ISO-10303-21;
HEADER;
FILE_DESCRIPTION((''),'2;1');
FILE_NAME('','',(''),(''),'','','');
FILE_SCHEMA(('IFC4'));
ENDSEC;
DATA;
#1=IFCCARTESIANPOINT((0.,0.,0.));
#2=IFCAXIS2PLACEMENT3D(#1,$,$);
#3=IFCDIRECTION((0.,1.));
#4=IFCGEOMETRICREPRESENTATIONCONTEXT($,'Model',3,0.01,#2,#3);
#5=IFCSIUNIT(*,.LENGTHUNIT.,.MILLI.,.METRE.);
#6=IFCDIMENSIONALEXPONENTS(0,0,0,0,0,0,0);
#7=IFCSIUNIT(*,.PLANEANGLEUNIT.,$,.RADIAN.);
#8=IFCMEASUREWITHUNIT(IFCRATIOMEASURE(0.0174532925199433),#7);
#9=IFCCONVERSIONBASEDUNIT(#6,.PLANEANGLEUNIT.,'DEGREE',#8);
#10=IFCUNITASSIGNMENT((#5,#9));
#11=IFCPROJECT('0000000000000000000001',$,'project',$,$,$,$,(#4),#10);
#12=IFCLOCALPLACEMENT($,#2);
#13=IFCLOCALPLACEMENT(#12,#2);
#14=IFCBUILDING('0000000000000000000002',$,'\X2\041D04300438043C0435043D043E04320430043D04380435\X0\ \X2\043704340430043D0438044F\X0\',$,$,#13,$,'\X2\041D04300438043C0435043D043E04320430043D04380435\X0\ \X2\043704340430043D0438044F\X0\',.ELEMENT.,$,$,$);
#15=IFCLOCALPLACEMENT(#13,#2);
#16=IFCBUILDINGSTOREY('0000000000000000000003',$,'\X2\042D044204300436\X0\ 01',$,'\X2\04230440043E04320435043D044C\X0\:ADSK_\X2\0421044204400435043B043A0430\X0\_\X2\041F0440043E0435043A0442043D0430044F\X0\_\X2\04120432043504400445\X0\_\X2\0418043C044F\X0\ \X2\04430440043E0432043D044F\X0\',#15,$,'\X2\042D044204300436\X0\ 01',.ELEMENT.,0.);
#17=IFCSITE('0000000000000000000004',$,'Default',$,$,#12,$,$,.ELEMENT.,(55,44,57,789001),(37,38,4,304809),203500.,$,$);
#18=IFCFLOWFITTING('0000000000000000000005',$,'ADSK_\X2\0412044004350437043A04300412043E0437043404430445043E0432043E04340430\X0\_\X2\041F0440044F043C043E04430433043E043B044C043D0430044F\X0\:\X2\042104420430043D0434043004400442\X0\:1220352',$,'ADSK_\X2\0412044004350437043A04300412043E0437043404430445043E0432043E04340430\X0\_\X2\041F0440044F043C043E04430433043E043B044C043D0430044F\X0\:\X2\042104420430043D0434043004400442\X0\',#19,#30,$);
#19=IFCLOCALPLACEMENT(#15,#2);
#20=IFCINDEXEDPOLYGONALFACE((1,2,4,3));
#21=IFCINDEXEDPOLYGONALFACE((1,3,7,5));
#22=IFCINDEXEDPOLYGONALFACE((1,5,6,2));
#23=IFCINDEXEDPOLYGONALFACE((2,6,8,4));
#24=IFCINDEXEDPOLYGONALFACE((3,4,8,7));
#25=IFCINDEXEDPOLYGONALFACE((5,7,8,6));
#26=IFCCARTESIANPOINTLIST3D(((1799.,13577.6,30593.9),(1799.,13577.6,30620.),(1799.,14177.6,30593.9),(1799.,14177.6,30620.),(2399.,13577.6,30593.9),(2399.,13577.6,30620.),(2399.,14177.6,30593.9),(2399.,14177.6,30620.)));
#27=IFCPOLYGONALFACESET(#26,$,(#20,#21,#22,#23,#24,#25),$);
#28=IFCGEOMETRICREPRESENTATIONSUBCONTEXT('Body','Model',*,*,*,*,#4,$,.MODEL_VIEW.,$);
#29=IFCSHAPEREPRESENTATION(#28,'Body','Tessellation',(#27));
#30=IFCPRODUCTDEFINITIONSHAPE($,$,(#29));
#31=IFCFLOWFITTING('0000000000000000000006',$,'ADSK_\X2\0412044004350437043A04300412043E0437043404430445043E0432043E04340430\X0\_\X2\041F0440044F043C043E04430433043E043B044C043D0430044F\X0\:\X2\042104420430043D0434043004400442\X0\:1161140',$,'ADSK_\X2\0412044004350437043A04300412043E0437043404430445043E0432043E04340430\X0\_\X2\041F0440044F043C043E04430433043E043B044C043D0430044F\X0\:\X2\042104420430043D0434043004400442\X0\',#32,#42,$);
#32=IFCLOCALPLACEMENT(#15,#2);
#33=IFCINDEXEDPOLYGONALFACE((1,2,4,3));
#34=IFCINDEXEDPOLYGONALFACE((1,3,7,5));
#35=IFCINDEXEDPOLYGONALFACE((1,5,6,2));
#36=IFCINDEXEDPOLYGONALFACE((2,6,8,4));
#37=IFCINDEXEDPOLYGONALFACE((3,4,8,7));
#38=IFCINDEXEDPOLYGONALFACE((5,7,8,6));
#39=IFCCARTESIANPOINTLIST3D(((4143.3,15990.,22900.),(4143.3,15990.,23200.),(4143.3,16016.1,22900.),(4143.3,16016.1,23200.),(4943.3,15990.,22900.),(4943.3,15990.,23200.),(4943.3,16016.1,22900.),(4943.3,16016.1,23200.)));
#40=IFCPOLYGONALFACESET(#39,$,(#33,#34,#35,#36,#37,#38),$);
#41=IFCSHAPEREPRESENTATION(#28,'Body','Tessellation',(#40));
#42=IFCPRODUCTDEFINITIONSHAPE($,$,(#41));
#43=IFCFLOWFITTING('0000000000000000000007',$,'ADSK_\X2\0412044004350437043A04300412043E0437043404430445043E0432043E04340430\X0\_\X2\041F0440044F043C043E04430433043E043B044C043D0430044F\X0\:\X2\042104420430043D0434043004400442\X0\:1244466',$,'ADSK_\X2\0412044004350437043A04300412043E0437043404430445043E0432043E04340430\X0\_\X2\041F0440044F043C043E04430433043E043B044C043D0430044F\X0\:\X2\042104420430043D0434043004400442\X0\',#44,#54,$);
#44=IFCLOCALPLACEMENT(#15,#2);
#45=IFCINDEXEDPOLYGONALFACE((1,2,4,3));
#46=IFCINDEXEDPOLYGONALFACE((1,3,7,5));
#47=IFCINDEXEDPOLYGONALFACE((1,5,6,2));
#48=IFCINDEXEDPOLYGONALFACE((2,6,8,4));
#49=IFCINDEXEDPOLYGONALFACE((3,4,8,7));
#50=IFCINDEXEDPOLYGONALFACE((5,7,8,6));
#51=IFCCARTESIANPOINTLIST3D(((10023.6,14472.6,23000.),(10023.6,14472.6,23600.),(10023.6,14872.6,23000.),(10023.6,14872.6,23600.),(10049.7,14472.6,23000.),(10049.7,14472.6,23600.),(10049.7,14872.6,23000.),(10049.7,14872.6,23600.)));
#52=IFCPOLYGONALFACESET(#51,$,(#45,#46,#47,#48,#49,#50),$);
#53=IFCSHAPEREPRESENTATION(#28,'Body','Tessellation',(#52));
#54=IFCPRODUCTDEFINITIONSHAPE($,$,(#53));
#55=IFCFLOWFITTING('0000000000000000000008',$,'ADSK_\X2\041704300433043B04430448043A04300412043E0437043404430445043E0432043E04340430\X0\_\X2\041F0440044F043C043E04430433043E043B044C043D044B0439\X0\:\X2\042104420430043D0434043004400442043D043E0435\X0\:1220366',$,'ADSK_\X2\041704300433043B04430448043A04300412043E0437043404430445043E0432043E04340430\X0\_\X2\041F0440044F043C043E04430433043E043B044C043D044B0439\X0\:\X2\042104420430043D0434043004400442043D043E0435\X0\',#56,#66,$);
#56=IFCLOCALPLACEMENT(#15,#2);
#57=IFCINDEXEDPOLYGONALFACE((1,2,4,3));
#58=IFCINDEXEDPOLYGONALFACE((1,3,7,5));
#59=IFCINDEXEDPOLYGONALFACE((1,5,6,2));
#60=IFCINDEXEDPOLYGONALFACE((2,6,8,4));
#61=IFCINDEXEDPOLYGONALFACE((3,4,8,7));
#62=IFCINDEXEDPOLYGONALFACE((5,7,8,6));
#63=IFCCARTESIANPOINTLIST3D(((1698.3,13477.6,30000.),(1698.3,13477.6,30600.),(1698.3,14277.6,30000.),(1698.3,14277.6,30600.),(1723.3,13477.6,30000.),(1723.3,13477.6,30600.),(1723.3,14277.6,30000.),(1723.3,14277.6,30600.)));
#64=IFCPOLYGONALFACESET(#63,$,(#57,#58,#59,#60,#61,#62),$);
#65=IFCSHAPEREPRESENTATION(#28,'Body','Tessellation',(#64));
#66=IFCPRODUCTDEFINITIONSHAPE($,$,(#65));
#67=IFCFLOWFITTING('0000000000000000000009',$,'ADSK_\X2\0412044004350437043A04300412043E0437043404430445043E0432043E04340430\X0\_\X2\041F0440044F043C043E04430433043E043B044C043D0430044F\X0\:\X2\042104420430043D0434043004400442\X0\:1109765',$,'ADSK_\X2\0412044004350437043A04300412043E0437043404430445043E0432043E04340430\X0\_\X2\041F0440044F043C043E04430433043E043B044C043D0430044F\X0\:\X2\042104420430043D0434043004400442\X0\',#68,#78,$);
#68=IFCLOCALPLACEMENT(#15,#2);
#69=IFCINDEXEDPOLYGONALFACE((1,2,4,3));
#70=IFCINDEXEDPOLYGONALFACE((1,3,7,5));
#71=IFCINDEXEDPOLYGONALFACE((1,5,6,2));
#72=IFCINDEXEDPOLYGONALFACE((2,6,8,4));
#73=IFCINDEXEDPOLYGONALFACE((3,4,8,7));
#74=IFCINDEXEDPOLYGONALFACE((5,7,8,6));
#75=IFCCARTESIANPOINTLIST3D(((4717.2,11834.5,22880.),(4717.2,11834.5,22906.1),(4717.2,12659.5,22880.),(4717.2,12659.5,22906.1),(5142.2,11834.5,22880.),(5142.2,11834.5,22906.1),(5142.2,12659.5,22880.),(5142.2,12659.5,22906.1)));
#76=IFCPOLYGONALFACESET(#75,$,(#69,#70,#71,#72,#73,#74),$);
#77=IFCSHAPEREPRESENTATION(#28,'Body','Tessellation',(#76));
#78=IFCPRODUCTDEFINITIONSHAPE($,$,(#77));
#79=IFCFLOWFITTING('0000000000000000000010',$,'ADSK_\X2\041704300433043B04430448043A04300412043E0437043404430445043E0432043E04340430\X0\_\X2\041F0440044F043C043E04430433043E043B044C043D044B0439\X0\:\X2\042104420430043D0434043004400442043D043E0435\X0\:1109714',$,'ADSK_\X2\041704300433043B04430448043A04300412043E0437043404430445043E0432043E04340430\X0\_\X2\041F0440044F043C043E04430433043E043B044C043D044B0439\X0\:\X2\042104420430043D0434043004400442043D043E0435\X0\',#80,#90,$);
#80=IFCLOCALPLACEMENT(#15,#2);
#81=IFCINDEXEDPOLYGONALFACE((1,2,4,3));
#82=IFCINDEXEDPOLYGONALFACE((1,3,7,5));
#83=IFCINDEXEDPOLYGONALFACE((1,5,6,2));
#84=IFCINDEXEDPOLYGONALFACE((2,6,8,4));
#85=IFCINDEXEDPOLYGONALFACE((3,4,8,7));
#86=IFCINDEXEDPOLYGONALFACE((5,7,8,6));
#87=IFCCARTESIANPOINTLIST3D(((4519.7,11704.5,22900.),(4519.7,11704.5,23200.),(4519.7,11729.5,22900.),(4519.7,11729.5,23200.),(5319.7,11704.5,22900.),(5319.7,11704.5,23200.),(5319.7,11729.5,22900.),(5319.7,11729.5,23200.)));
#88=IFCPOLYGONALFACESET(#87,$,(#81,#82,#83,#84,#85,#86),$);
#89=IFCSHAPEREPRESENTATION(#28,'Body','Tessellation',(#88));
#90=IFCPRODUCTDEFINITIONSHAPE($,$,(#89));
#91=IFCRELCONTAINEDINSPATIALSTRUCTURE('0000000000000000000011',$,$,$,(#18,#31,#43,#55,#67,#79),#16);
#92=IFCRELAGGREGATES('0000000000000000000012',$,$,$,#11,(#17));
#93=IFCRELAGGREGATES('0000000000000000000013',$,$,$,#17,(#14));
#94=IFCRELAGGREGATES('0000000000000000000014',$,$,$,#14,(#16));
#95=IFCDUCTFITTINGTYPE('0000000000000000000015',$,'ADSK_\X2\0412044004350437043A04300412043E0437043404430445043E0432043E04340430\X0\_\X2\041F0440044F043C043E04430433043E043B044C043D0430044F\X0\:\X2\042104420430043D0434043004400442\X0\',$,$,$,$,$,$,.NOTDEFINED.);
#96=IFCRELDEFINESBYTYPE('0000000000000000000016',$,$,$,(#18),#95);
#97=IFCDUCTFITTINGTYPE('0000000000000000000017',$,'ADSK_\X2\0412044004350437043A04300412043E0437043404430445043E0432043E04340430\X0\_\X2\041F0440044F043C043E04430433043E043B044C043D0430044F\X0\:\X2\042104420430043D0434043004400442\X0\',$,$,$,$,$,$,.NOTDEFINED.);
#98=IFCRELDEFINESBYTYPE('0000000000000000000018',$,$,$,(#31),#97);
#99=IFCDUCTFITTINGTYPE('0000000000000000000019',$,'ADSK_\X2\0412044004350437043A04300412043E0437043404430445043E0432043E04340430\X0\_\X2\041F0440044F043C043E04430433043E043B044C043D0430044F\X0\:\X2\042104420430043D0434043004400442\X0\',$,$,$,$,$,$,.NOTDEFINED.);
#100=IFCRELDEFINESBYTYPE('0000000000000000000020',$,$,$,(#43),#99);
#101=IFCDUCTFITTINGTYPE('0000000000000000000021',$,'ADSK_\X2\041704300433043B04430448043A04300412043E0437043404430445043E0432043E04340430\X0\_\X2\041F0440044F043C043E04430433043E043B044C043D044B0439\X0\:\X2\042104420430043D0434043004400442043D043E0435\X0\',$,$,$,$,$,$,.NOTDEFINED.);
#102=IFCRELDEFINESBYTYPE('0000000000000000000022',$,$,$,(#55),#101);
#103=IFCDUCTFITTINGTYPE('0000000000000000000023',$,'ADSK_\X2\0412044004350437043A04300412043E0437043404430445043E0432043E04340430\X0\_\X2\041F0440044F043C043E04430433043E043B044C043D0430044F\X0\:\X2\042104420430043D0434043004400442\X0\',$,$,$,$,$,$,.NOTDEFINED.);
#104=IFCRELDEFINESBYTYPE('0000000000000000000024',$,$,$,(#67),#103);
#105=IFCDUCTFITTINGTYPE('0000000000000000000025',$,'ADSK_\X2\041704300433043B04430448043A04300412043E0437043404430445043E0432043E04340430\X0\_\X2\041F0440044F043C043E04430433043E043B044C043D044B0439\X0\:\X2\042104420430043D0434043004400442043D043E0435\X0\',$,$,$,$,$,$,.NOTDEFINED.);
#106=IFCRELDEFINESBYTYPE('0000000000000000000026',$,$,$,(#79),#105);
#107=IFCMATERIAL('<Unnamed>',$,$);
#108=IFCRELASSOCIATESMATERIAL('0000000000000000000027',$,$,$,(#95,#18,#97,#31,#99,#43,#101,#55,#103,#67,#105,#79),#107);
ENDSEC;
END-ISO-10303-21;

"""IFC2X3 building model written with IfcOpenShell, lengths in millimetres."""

from ifc_helpers import new_model, entity, si_unit, converted_unit, direction, frame, origin, origin_2d_with_axis, place, context, subcontext, project, spatial, rectangle, extrude, source, transform, mapped, material, type_object, type_shapes, element, save


model = new_model("IFC2X3")

# Units and contexts
model_context = context("Model", 3, precision=0.01, world=origin(), true_north=direction((0.0, 1.0)))
body_context = subcontext(model_context, "Body", "Model", "MODEL_VIEW")
ifc_project = project(units=[si_unit("LENGTHUNIT", "METRE", prefix="MILLI"), converted_unit("PLANEANGLEUNIT", "DEGREE", entity("IfcRatioMeasure", 0.0174532925199433), si_unit("PLANEANGLEUNIT", "RADIAN"), dimensions=[0, 0, 0, 0, 0, 0, 0])], contexts=[model_context])

# Site, building, storey
site_placement = place(None, origin())
site = spatial("IfcSite", under=ifc_project, at=site_placement, Name="Default", CompositionType="ELEMENT", RefLatitude=(55, 44, 57, 789001), RefLongitude=(37, 38, 4, 304809), RefElevation=203500.0)
building_placement = place(site_placement, origin())
building = spatial("IfcBuilding", under=site, at=building_placement, Name="Наименование здания", LongName="Наименование здания", CompositionType="ELEMENT")
storey_placement = place(building_placement, origin())
storey = spatial("IfcBuildingStorey", under=building, at=storey_placement, Name="Этаж 01", ObjectType="Уровень:ADSK_Стрелка_Проектная_Вверх_Имя уровня", LongName="Этаж 01", CompositionType="ELEMENT", Elevation=0.0)

# Flow fittings
ifc_material_1 = material(Name="<Unnamed>")
duct_fitting_type_1 = type_object("IfcDuctFittingType", Name="ADSK_ВрезкаВоздуховода_Прямоугольная:Стандарт", PredefinedType="NOTDEFINED", material=ifc_material_1)
shared_shape_1 = source(origin(), body_context, "Body", "SweptSolid", [
    extrude(rectangle(XDim=600.0, YDim=26.1, at=origin_2d_with_axis()), frame((7.0, 0.0, -300.0), z_axis=(0.0, 0.0, 1.0), x_axis=(0.0, -1.0, 0.0)), (0.0, 0.0, 1.0), 600.0),
])
type_shapes(duct_fitting_type_1, [shared_shape_1])
flow_fitting_1_placement = place(storey_placement, frame((2099.0, 13877.6, 30600.0), z_axis=(0.0, -1.0, 0.0), x_axis=(0.0, 0.0, 1.0)))
element("IfcFlowFitting", 1, at=flow_fitting_1_placement, inside=storey, type_object=duct_fitting_type_1, material=ifc_material_1, Name="ADSK_ВрезкаВоздуховода_Прямоугольная:Стандарт:1220352", ObjectType="ADSK_ВрезкаВоздуховода_Прямоугольная:Стандарт", context=body_context, shape_type="MappedRepresentation", body=[
    mapped(shared_shape_1, transform((0.0, 0.0, 0.0), scale=1.0)),
])
duct_fitting_type_2 = type_object("IfcDuctFittingType", Name="ADSK_ВрезкаВоздуховода_Прямоугольная:Стандарт", PredefinedType="NOTDEFINED", material=ifc_material_1)
shared_shape_2 = source(origin(), body_context, "Body", "SweptSolid", [
    extrude(rectangle(XDim=26.1, YDim=300.0, at=origin_2d_with_axis()), frame((7.0, 0.0, -400.0)), (0.0, 0.0, 1.0), 800.0),
])
type_shapes(duct_fitting_type_2, [shared_shape_2])
flow_fitting_2_placement = place(storey_placement, frame((4543.3, 16010.0, 23050.0), z_axis=(-1.0, 0.0, 0.0), x_axis=(0.0, -1.0, 0.0)))
element("IfcFlowFitting", 2, at=flow_fitting_2_placement, inside=storey, type_object=duct_fitting_type_2, material=ifc_material_1, Name="ADSK_ВрезкаВоздуховода_Прямоугольная:Стандарт:1161140", ObjectType="ADSK_ВрезкаВоздуховода_Прямоугольная:Стандарт", context=body_context, shape_type="MappedRepresentation", body=[
    mapped(shared_shape_2, transform((0.0, 0.0, 0.0), scale=1.0)),
])
duct_fitting_type_3 = type_object("IfcDuctFittingType", Name="ADSK_ВрезкаВоздуховода_Прямоугольная:Стандарт", PredefinedType="NOTDEFINED", material=ifc_material_1)
shared_shape_3 = source(origin(), body_context, "Body", "SweptSolid", [
    extrude(rectangle(XDim=600.0, YDim=26.1, at=origin_2d_with_axis()), frame((7.0, 0.0, -200.0), z_axis=(0.0, 0.0, 1.0), x_axis=(0.0, -1.0, 0.0)), (0.0, 0.0, 1.0), 400.0),
])
type_shapes(duct_fitting_type_3, [shared_shape_3])
flow_fitting_3_placement = place(storey_placement, frame((10029.7, 14672.6, 23300.0), z_axis=(0.0, -1.0, 0.0), x_axis=(1.0, 0.0, 0.0)))
element("IfcFlowFitting", 3, at=flow_fitting_3_placement, inside=storey, type_object=duct_fitting_type_3, material=ifc_material_1, Name="ADSK_ВрезкаВоздуховода_Прямоугольная:Стандарт:1244466", ObjectType="ADSK_ВрезкаВоздуховода_Прямоугольная:Стандарт", context=body_context, shape_type="MappedRepresentation", body=[
    mapped(shared_shape_3, transform((0.0, 0.0, 0.0), scale=1.0)),
])
duct_fitting_type_4 = type_object("IfcDuctFittingType", Name="ADSK_ЗаглушкаВоздуховода_Прямоугольный:Стандартное", PredefinedType="NOTDEFINED", material=ifc_material_1)
shared_shape_4 = source(origin(), body_context, "Body", "SweptSolid", [
    extrude(rectangle(XDim=25.0, YDim=800.0, at=origin_2d_with_axis()), frame((12.5, 0.0, -300.0)), (0.0, 0.0, 1.0), 600.0),
])
type_shapes(duct_fitting_type_4, [shared_shape_4])
flow_fitting_4_placement = place(storey_placement, frame((1723.3, 13877.6, 30300.0), z_axis=(0.0, 0.0, 1.0), x_axis=(-1.0, 0.0, 0.0)))
element("IfcFlowFitting", 4, at=flow_fitting_4_placement, inside=storey, type_object=duct_fitting_type_4, material=ifc_material_1, Name="ADSK_ЗаглушкаВоздуховода_Прямоугольный:Стандартное:1220366", ObjectType="ADSK_ЗаглушкаВоздуховода_Прямоугольный:Стандартное", context=body_context, shape_type="MappedRepresentation", body=[
    mapped(shared_shape_4, transform((0.0, 0.0, 0.0), scale=1.0)),
])
duct_fitting_type_5 = type_object("IfcDuctFittingType", Name="ADSK_ВрезкаВоздуховода_Прямоугольная:Стандарт", PredefinedType="NOTDEFINED", material=ifc_material_1)
shared_shape_5 = source(origin(), body_context, "Body", "SweptSolid", [
    extrude(rectangle(XDim=825.0, YDim=26.1, at=origin_2d_with_axis()), frame((7.0, 0.0, -212.5), z_axis=(0.0, 0.0, 1.0), x_axis=(0.0, -1.0, 0.0)), (0.0, 0.0, 1.0), 425.0),
])
type_shapes(duct_fitting_type_5, [shared_shape_5])
flow_fitting_5_placement = place(storey_placement, frame((4929.7, 12247.0, 22900.0), z_axis=(-1.0, 0.0, 0.0), x_axis=(0.0, 0.0, -1.0)))
element("IfcFlowFitting", 5, at=flow_fitting_5_placement, inside=storey, type_object=duct_fitting_type_5, material=ifc_material_1, Name="ADSK_ВрезкаВоздуховода_Прямоугольная:Стандарт:1109765", ObjectType="ADSK_ВрезкаВоздуховода_Прямоугольная:Стандарт", context=body_context, shape_type="MappedRepresentation", body=[
    mapped(shared_shape_5, transform((0.0, 0.0, 0.0), scale=1.0)),
])
duct_fitting_type_6 = type_object("IfcDuctFittingType", Name="ADSK_ЗаглушкаВоздуховода_Прямоугольный:Стандартное", PredefinedType="NOTDEFINED", material=ifc_material_1)
shared_shape_6 = source(origin(), body_context, "Body", "SweptSolid", [
    extrude(rectangle(XDim=25.0, YDim=800.0, at=origin_2d_with_axis()), frame((12.5, 0.0, -150.0)), (0.0, 0.0, 1.0), 300.0),
])
type_shapes(duct_fitting_type_6, [shared_shape_6])
flow_fitting_6_placement = place(storey_placement, frame((4919.7, 11729.5, 23050.0), z_axis=(0.0, 0.0, 1.0), x_axis=(0.0, -1.0, 0.0)))
element("IfcFlowFitting", 6, at=flow_fitting_6_placement, inside=storey, type_object=duct_fitting_type_6, material=ifc_material_1, Name="ADSK_ЗаглушкаВоздуховода_Прямоугольный:Стандартное:1109714", ObjectType="ADSK_ЗаглушкаВоздуховода_Прямоугольный:Стандартное", context=body_context, shape_type="MappedRepresentation", body=[
    mapped(shared_shape_6, transform((0.0, 0.0, 0.0), scale=1.0)),
])

save(model, "model.ifc")
